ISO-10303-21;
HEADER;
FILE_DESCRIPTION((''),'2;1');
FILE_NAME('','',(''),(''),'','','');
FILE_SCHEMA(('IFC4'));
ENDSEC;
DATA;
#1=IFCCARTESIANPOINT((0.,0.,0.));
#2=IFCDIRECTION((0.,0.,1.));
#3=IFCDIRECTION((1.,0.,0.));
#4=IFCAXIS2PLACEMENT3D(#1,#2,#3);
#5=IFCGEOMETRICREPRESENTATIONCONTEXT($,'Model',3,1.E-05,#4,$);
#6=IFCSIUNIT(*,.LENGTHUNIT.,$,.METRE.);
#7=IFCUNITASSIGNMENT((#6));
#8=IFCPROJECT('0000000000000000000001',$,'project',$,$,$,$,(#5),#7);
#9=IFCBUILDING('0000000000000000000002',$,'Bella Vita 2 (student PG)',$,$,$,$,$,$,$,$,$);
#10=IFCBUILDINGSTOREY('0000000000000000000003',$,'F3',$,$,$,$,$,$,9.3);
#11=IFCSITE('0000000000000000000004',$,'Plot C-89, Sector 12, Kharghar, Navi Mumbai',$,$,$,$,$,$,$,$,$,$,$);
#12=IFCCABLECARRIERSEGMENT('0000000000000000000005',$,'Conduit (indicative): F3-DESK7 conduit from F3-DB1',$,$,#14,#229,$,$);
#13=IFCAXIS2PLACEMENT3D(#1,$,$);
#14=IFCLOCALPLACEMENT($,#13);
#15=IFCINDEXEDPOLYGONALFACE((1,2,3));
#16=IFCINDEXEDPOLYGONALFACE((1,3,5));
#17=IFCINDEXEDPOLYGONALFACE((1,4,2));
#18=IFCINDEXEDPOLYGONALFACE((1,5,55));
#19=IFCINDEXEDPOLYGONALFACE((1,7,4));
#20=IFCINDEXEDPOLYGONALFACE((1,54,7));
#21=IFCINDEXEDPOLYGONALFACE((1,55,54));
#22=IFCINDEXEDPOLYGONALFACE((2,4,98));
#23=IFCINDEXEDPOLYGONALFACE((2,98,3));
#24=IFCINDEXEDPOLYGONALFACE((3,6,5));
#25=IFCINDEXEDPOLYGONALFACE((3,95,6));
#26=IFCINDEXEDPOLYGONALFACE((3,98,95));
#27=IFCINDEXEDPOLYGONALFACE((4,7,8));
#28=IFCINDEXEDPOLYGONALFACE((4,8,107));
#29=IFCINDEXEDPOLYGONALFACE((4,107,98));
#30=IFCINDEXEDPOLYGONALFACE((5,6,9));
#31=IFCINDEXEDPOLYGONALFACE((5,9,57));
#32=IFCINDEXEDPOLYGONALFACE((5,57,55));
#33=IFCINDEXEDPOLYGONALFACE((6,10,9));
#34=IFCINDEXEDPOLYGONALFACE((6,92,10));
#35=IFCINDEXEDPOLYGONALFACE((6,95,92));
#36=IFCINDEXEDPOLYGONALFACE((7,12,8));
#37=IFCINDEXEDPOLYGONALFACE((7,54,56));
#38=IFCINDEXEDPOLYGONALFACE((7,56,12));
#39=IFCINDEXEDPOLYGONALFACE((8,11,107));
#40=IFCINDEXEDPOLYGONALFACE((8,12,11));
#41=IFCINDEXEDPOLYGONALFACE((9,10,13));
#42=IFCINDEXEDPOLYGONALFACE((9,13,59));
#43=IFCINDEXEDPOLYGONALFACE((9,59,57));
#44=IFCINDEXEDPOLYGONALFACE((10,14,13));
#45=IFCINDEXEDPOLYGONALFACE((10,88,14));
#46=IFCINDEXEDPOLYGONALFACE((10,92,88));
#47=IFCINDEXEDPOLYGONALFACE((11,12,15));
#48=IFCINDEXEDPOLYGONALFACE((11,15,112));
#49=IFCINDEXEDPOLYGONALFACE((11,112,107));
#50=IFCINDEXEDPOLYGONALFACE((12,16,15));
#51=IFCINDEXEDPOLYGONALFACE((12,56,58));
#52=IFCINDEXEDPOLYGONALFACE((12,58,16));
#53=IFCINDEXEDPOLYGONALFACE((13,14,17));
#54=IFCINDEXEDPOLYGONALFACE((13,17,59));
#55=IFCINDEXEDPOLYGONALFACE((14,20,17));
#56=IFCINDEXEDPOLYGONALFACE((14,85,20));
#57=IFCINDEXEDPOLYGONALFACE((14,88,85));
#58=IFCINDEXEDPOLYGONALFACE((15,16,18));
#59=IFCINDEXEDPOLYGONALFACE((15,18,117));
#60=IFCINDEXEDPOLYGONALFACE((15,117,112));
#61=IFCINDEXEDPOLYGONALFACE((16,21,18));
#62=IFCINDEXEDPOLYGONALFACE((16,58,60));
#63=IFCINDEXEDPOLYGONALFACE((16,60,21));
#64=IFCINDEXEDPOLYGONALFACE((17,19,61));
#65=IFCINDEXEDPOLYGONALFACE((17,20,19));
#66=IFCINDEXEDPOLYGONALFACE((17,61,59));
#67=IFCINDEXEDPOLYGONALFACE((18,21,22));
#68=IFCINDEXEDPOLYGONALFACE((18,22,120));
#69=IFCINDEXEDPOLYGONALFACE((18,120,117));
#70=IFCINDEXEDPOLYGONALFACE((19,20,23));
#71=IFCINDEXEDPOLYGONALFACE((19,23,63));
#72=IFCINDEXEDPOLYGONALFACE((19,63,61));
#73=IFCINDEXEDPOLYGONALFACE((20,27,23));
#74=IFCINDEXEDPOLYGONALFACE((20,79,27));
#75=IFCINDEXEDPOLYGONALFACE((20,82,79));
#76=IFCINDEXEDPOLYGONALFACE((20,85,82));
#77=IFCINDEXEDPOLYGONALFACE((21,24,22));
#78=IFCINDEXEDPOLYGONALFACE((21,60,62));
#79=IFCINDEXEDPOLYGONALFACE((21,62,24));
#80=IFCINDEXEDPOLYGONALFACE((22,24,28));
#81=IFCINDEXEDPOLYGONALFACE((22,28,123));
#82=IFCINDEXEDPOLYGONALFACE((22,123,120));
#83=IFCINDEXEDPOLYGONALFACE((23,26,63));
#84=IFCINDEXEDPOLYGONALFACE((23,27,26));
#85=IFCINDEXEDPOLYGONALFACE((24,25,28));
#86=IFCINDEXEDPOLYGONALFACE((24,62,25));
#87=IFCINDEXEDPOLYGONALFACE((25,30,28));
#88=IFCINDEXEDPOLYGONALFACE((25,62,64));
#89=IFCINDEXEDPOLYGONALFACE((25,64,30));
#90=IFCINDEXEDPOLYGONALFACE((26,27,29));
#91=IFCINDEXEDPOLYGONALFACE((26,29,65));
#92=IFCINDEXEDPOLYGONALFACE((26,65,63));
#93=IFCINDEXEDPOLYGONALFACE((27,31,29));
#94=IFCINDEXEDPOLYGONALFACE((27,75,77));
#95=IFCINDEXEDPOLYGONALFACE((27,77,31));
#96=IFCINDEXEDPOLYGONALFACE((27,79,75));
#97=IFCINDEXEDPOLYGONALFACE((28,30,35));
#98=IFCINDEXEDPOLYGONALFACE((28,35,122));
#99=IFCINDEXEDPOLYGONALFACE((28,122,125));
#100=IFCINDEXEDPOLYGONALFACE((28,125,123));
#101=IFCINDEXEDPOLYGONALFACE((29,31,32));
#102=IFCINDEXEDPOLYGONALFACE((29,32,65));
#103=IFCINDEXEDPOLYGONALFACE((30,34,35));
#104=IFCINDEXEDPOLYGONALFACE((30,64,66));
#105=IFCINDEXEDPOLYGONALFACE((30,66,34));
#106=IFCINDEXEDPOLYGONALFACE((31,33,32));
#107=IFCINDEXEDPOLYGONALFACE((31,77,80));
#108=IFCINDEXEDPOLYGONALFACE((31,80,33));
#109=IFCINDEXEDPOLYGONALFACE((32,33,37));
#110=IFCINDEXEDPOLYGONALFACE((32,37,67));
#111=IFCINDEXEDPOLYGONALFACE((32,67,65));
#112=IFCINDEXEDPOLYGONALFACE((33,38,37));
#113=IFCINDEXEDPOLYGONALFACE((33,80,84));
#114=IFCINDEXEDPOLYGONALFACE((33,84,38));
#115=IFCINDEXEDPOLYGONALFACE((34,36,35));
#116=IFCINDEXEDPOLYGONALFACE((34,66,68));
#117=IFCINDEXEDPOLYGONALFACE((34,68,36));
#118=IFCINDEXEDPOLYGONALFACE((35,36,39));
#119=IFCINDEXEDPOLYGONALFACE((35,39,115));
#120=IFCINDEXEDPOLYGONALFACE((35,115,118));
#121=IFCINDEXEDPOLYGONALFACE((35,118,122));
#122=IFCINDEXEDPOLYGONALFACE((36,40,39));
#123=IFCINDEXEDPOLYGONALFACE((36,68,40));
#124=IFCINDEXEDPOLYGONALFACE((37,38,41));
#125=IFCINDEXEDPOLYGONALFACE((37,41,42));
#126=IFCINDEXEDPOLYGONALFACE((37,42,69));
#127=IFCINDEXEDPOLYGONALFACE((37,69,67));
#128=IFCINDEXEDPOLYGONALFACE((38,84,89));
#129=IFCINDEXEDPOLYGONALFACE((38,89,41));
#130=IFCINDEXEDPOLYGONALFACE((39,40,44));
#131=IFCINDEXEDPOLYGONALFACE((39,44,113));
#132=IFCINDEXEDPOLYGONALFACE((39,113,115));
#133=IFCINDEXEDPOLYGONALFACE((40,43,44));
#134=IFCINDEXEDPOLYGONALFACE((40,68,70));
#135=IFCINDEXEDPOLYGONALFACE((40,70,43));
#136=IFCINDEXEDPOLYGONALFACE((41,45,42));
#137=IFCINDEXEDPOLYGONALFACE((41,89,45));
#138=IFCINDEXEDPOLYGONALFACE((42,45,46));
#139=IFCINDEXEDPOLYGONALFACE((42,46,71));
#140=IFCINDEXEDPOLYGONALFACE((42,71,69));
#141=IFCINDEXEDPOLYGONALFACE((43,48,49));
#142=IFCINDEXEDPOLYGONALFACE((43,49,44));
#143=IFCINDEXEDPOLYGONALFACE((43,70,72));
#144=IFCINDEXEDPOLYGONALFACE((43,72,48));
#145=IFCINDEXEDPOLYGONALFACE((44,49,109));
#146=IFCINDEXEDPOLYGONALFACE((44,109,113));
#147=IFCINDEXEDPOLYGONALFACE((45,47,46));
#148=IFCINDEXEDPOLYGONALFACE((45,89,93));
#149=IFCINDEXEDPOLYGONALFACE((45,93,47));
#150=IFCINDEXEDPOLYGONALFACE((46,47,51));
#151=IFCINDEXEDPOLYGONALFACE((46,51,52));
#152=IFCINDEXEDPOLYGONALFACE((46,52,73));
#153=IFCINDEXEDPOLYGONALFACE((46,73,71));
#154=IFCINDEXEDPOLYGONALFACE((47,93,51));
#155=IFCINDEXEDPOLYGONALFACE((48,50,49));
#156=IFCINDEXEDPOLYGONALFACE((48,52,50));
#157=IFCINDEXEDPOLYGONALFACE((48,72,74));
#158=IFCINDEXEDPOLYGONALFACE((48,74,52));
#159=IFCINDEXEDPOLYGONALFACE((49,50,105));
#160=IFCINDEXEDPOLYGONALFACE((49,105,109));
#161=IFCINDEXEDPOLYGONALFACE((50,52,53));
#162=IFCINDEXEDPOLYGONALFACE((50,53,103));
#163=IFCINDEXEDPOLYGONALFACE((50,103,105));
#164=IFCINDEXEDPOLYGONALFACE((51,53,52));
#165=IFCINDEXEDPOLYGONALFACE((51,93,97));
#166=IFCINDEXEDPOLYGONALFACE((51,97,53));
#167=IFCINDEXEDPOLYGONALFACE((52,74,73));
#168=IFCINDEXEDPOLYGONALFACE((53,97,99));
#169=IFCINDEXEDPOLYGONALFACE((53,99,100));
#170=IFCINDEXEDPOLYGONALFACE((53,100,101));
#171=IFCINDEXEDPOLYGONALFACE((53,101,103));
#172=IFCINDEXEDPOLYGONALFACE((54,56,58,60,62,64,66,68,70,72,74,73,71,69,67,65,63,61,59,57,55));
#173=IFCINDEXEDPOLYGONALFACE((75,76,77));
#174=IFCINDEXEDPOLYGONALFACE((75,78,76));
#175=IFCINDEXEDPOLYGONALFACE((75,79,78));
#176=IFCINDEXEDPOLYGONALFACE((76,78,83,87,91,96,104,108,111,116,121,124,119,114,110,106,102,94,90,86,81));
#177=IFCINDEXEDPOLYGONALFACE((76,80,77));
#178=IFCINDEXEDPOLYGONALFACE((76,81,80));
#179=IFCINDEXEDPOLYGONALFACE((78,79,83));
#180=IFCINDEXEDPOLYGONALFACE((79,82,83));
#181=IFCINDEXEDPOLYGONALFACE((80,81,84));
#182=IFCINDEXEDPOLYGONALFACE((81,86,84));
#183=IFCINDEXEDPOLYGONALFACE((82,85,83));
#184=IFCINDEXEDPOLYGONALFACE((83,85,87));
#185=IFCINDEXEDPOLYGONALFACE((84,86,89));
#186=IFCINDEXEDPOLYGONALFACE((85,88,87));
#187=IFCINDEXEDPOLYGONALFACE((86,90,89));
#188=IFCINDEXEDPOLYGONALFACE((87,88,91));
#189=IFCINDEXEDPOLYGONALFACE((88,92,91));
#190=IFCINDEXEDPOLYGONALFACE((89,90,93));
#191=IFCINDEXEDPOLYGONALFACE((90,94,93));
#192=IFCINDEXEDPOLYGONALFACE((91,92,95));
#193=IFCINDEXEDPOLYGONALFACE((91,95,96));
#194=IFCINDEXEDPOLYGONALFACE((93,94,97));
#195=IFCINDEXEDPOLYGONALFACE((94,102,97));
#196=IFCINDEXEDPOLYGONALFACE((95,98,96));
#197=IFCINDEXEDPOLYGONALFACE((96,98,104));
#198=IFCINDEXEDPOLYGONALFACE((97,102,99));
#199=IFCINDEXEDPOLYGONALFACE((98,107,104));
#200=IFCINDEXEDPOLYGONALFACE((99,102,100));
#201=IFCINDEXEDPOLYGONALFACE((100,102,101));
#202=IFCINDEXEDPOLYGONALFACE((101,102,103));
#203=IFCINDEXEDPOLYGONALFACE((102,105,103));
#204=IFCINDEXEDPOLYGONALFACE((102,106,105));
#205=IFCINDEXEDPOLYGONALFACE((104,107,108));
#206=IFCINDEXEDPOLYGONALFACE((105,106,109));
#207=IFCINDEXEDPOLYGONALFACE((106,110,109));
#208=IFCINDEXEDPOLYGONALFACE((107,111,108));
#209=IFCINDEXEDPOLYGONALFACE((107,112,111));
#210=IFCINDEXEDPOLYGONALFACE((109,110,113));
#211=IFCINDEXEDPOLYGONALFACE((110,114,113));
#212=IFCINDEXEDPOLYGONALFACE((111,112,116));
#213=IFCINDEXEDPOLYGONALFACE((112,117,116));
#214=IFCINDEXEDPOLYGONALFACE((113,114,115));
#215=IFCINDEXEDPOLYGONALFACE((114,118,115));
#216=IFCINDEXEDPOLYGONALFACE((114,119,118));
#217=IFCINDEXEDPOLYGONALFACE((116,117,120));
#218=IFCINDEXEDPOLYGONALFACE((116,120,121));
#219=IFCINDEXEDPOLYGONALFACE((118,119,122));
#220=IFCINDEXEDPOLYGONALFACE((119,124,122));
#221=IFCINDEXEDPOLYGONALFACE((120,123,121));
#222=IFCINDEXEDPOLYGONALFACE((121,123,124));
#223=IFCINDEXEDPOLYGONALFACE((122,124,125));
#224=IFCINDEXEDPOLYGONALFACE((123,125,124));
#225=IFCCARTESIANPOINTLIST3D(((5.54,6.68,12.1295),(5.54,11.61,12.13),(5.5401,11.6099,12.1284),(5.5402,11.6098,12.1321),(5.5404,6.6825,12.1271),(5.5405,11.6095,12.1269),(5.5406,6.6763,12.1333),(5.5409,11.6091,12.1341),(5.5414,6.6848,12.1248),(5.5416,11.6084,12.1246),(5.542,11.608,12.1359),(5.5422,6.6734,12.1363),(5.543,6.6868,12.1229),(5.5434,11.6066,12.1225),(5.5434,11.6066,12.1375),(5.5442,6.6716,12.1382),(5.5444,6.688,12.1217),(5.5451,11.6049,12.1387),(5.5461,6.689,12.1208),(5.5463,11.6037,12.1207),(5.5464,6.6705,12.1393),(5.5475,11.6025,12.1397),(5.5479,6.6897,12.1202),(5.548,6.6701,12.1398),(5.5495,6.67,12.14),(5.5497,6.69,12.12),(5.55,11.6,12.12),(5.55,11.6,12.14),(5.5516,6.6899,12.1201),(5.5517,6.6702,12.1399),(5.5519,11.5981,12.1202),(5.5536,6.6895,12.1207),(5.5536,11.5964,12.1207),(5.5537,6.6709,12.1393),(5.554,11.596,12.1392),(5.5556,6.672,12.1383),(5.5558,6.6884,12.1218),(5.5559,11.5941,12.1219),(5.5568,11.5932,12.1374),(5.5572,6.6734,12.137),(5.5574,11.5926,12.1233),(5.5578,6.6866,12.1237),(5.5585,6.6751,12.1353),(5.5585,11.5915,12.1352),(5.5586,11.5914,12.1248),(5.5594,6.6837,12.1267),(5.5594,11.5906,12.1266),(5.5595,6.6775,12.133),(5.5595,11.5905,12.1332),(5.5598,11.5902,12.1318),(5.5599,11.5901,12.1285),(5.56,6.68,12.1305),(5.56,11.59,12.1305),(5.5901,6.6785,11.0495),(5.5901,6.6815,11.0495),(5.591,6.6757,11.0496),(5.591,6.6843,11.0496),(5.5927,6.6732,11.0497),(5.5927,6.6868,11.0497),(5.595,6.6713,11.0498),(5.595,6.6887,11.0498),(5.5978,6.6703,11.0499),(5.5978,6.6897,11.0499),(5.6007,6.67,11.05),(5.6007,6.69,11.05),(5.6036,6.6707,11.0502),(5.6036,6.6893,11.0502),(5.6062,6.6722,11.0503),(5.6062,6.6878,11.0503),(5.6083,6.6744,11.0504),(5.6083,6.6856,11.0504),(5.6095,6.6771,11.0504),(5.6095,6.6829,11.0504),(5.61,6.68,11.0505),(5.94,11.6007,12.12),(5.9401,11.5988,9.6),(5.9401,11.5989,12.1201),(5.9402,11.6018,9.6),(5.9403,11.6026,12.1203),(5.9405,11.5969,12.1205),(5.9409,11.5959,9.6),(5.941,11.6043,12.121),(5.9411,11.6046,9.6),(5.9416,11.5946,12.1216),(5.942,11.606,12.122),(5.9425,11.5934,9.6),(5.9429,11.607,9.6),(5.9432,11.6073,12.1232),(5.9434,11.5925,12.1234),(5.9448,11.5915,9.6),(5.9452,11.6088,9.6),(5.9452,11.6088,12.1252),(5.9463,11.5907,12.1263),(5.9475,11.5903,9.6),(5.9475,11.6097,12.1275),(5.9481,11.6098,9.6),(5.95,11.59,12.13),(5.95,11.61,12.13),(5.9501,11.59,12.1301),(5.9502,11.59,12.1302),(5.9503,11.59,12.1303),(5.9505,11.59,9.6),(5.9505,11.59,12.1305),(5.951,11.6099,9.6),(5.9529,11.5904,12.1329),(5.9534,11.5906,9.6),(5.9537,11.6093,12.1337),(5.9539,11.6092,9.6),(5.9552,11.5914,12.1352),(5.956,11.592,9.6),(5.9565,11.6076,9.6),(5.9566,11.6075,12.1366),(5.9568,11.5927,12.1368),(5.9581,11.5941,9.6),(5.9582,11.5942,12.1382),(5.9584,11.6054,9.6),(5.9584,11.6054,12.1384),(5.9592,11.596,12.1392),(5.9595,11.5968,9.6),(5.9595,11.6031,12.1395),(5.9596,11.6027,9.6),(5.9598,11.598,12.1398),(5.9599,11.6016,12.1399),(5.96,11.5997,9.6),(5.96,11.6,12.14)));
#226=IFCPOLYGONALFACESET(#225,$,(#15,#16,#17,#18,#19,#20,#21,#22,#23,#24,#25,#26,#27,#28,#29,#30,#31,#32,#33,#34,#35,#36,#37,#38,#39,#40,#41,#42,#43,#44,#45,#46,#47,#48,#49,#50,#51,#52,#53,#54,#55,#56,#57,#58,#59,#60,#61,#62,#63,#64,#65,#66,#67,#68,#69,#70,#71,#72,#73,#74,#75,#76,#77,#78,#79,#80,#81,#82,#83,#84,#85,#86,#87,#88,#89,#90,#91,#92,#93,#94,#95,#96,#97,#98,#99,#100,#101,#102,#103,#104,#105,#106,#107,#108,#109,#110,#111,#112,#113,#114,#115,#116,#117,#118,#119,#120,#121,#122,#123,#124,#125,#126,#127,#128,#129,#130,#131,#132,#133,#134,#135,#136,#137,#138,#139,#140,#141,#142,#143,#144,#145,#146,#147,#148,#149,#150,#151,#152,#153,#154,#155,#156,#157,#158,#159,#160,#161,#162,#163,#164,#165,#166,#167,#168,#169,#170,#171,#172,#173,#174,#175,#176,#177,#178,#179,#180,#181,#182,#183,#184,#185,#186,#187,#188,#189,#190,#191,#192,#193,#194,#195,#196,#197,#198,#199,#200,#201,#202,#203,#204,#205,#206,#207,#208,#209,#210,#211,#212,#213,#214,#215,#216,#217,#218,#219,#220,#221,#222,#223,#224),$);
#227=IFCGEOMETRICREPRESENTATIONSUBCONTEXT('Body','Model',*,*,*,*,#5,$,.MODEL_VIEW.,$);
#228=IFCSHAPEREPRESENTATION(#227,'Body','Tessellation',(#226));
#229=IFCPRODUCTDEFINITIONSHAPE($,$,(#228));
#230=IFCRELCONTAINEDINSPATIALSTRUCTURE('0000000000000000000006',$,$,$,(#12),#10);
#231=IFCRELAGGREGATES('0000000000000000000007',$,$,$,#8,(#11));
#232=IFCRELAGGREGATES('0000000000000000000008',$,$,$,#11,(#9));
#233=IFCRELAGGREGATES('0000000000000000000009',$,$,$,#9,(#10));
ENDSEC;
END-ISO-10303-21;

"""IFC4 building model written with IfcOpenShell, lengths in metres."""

from ifc_helpers import new_model, entity, si_unit, origin, origin_with_axes, place, context, subcontext, project, spatial, element, save


model = new_model("IFC4")

# Units and contexts
model_context = context("Model", 3, precision=1e-05, world=origin_with_axes())
body_context = subcontext(model_context, "Body", "Model", "MODEL_VIEW")
ifc_project = project(units=[si_unit("LENGTHUNIT", "METRE")], contexts=[model_context])

# Site, building, storey
site = spatial("IfcSite", under=ifc_project, Name="Plot C-89, Sector 12, Kharghar, Navi Mumbai")
building = spatial("IfcBuilding", under=site, Name="Bella Vita 2 (student PG)")
storey = spatial("IfcBuildingStorey", under=building, Name="F3", Elevation=9.3)

# Cable carrier segment
cable_carrier_segment_1_placement = place(None, origin())
element("IfcCableCarrierSegment", 1, at=cable_carrier_segment_1_placement, inside=storey, Name="Conduit (indicative): F3-DESK7 conduit from F3-DB1", context=body_context, shape_type="AdvancedSweptSolid", body=[
    entity("IfcSweptDiskSolid", entity("IfcPolyline", [entity("IfcCartesianPoint", [5.6, 6.68, 11.05]), entity("IfcCartesianPoint", [5.55, 6.68, 12.13]), entity("IfcCartesianPoint", [5.55, 11.6, 12.13]), entity("IfcCartesianPoint", [5.95, 11.6, 12.13]), entity("IfcCartesianPoint", [5.95, 11.6, 9.6])]), 0.01),
])

save(model, "model.ifc")
